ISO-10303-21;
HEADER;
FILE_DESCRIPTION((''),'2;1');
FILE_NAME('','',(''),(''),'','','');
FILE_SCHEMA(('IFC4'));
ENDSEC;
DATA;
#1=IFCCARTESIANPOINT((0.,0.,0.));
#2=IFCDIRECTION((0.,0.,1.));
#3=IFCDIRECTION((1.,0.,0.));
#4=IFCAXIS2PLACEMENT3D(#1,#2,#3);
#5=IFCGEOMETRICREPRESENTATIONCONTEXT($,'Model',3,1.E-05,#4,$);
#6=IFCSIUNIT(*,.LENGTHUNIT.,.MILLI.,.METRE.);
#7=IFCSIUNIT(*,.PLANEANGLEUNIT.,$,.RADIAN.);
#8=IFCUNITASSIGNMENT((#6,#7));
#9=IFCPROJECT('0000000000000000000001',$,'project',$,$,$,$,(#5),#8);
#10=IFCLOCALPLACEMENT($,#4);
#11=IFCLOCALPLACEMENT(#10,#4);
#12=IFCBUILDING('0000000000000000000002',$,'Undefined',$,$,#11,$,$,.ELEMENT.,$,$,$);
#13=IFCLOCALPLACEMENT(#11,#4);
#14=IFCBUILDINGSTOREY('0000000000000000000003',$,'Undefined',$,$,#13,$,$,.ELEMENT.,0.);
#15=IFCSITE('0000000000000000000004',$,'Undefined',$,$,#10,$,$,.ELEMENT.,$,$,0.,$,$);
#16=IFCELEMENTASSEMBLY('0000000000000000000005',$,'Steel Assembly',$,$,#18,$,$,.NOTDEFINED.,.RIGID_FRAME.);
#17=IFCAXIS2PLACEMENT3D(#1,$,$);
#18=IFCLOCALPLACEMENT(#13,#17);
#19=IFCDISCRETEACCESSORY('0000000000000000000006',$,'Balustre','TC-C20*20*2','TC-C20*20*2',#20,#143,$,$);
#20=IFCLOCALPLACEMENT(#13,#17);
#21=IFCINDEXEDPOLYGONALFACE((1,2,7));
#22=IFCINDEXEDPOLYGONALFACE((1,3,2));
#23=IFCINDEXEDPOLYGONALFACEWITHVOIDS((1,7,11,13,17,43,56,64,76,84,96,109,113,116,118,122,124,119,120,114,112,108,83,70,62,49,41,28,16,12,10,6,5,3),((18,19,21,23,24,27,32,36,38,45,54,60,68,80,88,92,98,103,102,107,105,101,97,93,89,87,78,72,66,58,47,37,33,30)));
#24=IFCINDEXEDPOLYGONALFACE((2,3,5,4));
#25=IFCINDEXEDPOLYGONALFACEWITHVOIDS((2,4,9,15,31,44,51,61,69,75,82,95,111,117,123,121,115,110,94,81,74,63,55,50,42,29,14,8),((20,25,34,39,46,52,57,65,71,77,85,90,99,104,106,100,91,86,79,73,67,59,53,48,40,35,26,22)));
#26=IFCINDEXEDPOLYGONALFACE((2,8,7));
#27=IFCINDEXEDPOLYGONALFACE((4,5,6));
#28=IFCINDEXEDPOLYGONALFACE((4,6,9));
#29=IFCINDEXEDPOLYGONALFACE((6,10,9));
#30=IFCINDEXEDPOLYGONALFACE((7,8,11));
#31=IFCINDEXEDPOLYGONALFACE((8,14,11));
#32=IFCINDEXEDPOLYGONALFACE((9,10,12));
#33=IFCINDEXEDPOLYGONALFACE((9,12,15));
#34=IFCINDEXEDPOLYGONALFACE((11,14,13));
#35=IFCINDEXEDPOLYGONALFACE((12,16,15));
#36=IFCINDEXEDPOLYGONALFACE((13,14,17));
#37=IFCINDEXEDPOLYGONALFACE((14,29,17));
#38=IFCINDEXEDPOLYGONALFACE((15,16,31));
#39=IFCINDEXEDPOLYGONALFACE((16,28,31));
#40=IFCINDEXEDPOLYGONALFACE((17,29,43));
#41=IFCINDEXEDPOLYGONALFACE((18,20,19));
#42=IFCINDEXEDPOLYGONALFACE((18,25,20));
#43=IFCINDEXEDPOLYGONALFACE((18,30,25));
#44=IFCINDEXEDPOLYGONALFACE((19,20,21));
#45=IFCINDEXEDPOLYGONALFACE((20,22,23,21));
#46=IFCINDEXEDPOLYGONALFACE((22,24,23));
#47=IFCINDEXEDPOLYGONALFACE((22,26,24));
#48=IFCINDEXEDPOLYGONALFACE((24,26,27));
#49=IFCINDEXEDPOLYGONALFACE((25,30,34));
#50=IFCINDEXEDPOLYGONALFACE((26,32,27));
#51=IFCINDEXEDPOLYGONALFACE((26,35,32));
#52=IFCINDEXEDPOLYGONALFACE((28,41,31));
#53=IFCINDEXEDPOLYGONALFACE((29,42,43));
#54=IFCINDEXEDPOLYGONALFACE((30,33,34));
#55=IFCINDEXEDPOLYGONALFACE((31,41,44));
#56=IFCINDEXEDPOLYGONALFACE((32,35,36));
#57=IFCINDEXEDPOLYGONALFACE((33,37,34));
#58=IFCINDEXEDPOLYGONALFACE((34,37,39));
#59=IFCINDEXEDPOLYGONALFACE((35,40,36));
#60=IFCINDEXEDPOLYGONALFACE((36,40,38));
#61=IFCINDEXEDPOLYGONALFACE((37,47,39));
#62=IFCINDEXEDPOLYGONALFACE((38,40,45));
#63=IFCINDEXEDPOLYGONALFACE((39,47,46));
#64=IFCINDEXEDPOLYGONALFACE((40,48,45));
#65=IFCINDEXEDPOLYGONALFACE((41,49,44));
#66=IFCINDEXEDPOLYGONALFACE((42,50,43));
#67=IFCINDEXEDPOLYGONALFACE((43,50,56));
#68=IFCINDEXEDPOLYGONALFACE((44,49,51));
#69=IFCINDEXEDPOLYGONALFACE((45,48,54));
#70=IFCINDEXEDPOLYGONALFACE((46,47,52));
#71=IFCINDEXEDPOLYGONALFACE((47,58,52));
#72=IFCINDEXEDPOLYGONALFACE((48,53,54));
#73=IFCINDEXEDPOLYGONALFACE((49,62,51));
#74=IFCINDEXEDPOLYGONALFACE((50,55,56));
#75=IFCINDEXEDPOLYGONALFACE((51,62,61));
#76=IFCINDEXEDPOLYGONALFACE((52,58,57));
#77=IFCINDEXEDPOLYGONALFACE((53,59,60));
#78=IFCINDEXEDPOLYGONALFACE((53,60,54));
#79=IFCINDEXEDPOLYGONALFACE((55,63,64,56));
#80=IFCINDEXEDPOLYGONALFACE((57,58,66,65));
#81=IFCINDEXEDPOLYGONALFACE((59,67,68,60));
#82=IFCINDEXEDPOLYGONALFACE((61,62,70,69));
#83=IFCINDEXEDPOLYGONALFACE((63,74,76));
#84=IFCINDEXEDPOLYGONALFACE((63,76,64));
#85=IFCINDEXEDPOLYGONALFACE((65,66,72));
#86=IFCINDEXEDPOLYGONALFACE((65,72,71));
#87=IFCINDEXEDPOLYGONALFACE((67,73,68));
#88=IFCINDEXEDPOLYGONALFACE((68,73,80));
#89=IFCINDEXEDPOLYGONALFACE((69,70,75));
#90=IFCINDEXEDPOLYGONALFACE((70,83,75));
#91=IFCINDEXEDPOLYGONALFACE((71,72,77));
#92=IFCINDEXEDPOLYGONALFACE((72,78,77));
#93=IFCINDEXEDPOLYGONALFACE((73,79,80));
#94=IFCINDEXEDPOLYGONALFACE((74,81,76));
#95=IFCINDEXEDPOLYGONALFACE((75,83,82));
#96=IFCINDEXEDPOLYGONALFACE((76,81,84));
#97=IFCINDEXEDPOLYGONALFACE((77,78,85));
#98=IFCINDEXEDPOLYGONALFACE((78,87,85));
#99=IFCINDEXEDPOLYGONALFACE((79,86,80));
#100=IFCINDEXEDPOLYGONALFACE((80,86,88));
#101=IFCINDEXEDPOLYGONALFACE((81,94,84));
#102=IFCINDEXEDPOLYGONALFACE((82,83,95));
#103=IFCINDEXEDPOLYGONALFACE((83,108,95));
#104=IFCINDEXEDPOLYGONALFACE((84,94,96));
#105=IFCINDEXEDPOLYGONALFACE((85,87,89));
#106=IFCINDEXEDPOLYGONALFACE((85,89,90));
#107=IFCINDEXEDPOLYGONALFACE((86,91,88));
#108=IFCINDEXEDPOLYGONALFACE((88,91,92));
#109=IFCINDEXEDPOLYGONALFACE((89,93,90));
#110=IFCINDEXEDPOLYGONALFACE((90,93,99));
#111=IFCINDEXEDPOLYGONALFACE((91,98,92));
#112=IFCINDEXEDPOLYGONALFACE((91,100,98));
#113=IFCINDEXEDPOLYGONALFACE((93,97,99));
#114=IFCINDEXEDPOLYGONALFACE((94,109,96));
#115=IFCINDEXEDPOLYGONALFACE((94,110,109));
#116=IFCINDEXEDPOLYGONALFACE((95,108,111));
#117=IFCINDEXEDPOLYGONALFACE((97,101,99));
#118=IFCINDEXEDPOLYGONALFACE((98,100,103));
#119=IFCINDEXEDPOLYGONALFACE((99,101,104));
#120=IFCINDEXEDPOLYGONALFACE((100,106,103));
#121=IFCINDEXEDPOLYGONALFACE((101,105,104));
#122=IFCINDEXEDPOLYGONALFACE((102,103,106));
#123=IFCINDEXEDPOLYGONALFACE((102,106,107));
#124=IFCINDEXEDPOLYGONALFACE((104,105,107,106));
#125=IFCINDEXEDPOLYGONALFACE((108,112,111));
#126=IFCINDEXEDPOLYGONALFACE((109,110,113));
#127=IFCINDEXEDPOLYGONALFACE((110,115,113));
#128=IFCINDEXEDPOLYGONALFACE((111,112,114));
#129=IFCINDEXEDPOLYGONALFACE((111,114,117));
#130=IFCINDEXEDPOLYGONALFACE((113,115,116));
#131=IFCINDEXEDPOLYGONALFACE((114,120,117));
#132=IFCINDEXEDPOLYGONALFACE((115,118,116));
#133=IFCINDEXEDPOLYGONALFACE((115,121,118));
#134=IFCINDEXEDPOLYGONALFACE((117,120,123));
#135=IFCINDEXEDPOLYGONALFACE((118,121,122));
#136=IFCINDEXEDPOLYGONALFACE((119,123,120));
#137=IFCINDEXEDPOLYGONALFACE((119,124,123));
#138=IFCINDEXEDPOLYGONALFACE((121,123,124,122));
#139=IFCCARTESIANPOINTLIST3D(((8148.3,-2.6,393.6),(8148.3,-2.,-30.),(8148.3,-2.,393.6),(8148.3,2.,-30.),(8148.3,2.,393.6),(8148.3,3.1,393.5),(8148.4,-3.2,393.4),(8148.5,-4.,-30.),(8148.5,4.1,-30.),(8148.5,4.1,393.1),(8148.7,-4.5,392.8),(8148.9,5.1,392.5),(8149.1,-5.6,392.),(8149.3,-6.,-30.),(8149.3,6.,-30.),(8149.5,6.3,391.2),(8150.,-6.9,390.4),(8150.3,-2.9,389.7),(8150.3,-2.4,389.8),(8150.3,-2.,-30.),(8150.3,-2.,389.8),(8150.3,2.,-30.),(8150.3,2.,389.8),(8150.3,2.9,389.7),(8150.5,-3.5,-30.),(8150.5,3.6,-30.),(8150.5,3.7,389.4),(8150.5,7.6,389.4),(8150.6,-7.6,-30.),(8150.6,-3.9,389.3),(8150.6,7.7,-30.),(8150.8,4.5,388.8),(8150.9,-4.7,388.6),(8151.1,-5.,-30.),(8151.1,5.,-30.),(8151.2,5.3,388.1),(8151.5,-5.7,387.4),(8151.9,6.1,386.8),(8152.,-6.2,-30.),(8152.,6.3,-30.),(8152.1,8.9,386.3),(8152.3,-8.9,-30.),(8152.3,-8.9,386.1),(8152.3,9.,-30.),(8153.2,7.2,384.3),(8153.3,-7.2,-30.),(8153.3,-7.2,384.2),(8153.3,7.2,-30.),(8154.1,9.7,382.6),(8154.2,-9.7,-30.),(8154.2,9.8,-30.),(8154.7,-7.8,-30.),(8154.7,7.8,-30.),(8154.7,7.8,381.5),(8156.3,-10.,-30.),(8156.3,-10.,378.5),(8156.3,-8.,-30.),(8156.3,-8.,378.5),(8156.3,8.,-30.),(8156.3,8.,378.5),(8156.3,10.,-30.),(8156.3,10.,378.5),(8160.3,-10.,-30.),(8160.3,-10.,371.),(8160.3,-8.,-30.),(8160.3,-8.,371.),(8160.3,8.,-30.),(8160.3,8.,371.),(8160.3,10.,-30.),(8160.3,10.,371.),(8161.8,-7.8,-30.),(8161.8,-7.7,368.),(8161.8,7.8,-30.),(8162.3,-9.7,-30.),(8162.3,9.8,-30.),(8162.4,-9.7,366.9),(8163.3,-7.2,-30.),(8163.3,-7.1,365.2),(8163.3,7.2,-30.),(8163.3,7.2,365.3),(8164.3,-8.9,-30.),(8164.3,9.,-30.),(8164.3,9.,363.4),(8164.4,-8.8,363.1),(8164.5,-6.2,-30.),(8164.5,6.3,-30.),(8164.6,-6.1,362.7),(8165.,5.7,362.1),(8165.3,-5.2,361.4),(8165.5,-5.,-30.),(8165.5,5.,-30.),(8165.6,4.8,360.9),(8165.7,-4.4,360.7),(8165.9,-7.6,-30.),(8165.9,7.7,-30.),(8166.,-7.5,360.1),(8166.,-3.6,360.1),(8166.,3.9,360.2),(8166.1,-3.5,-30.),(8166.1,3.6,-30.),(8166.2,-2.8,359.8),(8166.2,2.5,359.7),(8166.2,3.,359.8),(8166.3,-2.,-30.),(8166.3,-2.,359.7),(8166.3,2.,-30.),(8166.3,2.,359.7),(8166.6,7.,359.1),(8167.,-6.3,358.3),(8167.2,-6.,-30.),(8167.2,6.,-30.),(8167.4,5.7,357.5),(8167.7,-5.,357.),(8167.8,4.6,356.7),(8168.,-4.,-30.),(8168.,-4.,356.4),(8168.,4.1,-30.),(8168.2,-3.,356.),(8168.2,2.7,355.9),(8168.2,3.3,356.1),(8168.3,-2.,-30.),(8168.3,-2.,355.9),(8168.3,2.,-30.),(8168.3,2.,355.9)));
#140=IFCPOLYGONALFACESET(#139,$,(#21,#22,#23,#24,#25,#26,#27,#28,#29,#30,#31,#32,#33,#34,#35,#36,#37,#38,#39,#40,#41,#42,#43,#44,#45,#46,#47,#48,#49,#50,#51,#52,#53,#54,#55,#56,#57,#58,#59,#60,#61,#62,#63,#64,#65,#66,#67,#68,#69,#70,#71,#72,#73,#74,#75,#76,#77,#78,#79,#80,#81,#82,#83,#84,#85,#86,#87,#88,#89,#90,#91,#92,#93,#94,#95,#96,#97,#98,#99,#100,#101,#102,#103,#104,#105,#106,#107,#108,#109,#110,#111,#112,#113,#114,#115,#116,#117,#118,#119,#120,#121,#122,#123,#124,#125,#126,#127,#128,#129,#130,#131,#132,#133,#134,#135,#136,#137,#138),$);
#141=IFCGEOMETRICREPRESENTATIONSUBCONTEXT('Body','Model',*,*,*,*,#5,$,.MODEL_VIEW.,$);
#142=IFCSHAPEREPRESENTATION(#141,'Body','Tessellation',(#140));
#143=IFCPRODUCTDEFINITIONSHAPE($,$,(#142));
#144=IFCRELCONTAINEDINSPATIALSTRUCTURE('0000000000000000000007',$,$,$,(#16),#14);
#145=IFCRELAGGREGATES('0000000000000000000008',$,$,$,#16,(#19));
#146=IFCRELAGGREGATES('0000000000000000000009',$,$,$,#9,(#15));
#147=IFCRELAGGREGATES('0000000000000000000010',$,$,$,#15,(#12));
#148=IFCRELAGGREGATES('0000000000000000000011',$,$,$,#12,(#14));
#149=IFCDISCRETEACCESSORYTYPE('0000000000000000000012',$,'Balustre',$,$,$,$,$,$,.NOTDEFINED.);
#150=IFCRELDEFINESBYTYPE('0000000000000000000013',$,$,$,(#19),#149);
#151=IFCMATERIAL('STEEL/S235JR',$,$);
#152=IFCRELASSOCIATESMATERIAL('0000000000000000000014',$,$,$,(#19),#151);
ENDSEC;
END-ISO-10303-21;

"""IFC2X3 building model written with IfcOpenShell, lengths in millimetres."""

from ifc_helpers import new_model, si_unit, frame, origin_with_axes, origin_2d_with_axis, place, context, subcontext, project, spatial, hollow_rectangle, extrude, clip, halfspace, material, type_object, element, aggregate, save


model = new_model("IFC2X3")

# Units and contexts
model_context = context("Model", 3, precision=1e-05, world=origin_with_axes())
body_context = subcontext(model_context, "Body", "Model", "MODEL_VIEW")
ifc_project = project(units=[si_unit("LENGTHUNIT", "METRE", prefix="MILLI"), si_unit("PLANEANGLEUNIT", "RADIAN")], contexts=[model_context])

# Site, building, storey
site_placement = place(None, origin_with_axes())
site = spatial("IfcSite", under=ifc_project, at=site_placement, Name="Undefined", CompositionType="ELEMENT", RefElevation=0.0)
building_placement = place(site_placement, origin_with_axes())
building = spatial("IfcBuilding", under=site, at=building_placement, Name="Undefined", CompositionType="ELEMENT")
storey_placement = place(building_placement, origin_with_axes())
storey = spatial("IfcBuildingStorey", under=building, at=storey_placement, Name="Undefined", CompositionType="ELEMENT", Elevation=0.0)

# Shared definitions
ifc_material = material(Name="STEEL/S235JR")

# Element assembly, discrete accessory
assembly_1_placement = place(storey_placement, origin_with_axes())
assembly_1 = element("IfcElementAssembly", 1, at=assembly_1_placement, inside=storey, Name="Steel Assembly", AssemblyPlace="NOTDEFINED", PredefinedType="RIGID_FRAME")
discrete_accessory_type_1 = type_object("IfcDiscreteAccessoryType", Name="Balustre")
discrete_accessory_1_placement = place(assembly_1_placement, frame((8158.3, 0.0, -30.0), z_axis=(0.0, 0.0, 1.0), x_axis=(1.0, 0.0, 0.0)))
discrete_accessory_1 = element("IfcDiscreteAccessory", 2, at=discrete_accessory_1_placement, type_object=discrete_accessory_type_1, material=ifc_material, Name="Balustre", Description="TC-C20*20*2", ObjectType="TC-C20*20*2", context=body_context, shape_type="Clipping", body=[
    clip(extrude(hollow_rectangle(XDim=20.0, YDim=20.0, WallThickness=2.0, InnerFilletRadius=6.0, OuterFilletRadius=8.0, at=origin_2d_with_axis()), frame((0.0, 0.0, 423.8), z_axis=(0.0, 0.0, -1.0), x_axis=(-1.0, -0.000011, 0.0)), (0.0, 0.0, 1.0), 423.8), halfspace(frame((63.3, 0.0, 285.4), z_axis=(-0.883506, -0.000005, -0.46842), x_axis=(-0.000005, 1.0, 0.0)), True)),
])

aggregate(assembly_1, [discrete_accessory_1])

save(model, "model.ifc")
